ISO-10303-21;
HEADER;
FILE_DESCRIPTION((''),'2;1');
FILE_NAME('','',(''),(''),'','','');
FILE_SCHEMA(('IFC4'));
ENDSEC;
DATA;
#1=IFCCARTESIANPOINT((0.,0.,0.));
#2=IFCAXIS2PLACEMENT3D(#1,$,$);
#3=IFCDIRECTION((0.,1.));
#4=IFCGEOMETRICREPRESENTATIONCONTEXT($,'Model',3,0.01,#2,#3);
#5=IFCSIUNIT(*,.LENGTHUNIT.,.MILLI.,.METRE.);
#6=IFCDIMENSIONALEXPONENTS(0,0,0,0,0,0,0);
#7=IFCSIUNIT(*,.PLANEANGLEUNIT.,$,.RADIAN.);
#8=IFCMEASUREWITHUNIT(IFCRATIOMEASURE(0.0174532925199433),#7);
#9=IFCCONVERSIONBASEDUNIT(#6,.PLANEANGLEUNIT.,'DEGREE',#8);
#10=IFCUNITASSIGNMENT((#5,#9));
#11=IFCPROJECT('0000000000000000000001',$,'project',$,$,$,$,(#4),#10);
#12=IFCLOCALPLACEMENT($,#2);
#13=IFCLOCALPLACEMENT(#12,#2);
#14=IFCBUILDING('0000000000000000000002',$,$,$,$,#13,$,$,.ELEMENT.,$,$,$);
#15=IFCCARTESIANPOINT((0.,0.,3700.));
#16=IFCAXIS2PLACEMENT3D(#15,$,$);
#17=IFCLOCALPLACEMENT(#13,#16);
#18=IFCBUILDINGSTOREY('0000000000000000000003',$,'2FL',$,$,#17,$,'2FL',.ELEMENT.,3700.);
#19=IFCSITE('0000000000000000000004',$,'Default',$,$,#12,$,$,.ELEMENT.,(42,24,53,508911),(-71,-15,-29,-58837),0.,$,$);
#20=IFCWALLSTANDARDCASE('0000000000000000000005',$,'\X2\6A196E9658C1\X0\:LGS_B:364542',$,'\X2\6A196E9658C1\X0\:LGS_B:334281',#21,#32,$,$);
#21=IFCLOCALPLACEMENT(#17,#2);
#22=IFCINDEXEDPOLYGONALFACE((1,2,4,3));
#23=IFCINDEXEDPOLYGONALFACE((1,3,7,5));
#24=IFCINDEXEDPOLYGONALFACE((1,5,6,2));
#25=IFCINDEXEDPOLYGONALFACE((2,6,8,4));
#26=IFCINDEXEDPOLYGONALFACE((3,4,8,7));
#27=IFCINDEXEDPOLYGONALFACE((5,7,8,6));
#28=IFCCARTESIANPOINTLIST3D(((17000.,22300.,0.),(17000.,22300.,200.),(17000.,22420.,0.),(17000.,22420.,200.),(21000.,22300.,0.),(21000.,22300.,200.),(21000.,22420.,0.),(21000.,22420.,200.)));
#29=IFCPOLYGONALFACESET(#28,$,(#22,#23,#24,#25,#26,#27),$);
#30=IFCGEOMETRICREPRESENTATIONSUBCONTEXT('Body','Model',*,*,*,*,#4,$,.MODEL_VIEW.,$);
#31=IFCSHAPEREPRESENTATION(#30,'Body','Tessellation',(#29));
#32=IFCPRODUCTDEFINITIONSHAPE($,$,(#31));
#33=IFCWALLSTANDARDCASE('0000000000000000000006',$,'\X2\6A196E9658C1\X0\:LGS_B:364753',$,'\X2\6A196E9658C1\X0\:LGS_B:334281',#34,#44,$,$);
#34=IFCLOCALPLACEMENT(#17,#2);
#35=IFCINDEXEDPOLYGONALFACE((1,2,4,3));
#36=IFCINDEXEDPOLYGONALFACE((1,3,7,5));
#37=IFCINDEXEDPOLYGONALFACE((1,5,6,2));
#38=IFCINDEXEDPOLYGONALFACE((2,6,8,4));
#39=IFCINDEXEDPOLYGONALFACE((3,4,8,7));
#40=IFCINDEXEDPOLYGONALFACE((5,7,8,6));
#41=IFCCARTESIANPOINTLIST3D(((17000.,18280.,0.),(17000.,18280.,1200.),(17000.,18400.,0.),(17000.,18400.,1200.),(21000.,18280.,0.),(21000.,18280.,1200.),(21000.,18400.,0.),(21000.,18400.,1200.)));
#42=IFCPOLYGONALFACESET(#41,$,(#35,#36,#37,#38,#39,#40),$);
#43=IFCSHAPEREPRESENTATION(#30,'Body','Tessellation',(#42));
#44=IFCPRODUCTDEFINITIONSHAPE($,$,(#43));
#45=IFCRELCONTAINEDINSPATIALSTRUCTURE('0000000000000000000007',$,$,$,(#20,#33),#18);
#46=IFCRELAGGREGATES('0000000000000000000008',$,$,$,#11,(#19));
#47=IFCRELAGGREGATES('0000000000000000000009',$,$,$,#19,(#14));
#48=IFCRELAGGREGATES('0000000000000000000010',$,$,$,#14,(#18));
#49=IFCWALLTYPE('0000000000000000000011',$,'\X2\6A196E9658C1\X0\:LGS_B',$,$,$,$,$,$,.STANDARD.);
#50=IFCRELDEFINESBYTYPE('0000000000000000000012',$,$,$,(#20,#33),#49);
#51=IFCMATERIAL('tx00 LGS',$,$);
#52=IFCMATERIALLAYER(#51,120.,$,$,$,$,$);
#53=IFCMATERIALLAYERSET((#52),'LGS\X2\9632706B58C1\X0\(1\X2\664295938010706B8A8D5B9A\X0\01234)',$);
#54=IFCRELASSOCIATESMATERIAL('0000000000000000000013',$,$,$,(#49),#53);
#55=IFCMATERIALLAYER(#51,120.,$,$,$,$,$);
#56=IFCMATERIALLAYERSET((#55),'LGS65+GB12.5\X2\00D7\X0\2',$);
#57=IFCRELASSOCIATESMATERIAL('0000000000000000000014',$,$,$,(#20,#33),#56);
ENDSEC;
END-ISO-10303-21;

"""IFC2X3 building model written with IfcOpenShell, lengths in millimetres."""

from ifc_helpers import new_model, entity, si_unit, converted_unit, direction, frame, frame_2d, origin, place, context, subcontext, project, spatial, rectangle, extrude, material, layer, layer_set, layer_usage, type_object, element, save


model = new_model("IFC2X3")

# Units and contexts
model_context = context("Model", 3, precision=0.01, world=origin(), true_north=direction((0.0, 1.0)))
body_context = subcontext(model_context, "Body", "Model", "MODEL_VIEW")
ifc_project = project(units=[si_unit("LENGTHUNIT", "METRE", prefix="MILLI"), converted_unit("PLANEANGLEUNIT", "DEGREE", entity("IfcRatioMeasure", 0.0174532925199433), si_unit("PLANEANGLEUNIT", "RADIAN"), dimensions=[0, 0, 0, 0, 0, 0, 0])], contexts=[model_context])

# Site, building, storey
site_placement = place(None, origin())
site = spatial("IfcSite", under=ifc_project, at=site_placement, Name="Default", CompositionType="ELEMENT", RefLatitude=(42, 24, 53, 508911), RefLongitude=(-71, -15, -29, -58837), RefElevation=0.0)
building_placement = place(site_placement, origin())
building = spatial("IfcBuilding", under=site, at=building_placement, CompositionType="ELEMENT")
storey_placement = place(building_placement, frame((0.0, 0.0, 3700.0)))
storey = spatial("IfcBuildingStorey", under=building, at=storey_placement, Name="2FL", LongName="2FL", CompositionType="ELEMENT", Elevation=3700.0)

# Walls
ifc_material_1 = material(Name="tx00 LGS")
ifc_layer_1 = layer(ifc_material_1, 120.0)
ifc_layer_set_1 = layer_set([ifc_layer_1], Name="LGS65+GB12.5×2")
ifc_layer_2 = layer(ifc_material_1, 120.0)
ifc_layer_set_2 = layer_set([ifc_layer_2], Name="LGS防火壁(1時間耐火認定01234)")
wall_type_1 = type_object("IfcWallType", Name="標準壁:LGS_B", PredefinedType="STANDARD", material=ifc_layer_set_2)
ifc_layer_usage_1 = layer_usage(ifc_layer_set_1, "AXIS2", "NEGATIVE", 60.0)
wall_1_placement = place(storey_placement, frame((21000.0, 22360.0, 0.0), z_axis=(0.0, 0.0, 1.0), x_axis=(-1.0, 0.0, 0.0)))
element("IfcWallStandardCase", 1, at=wall_1_placement, inside=storey, type_object=wall_type_1, material=ifc_layer_usage_1, Name="標準壁:LGS_B:364542", ObjectType="標準壁:LGS_B:334281", context=body_context, shape_type="SweptSolid", body=[
    extrude(rectangle(XDim=4000.0, YDim=120.0, at=frame_2d((2000.0, 0.0), x_axis=(-1.0, 0.0))), origin(), (0.0, 0.0, 1.0), 200.0),
])
ifc_layer_usage_2 = layer_usage(ifc_layer_set_1, "AXIS2", "NEGATIVE", 60.0)
wall_2_placement = place(storey_placement, frame((17000.0, 18340.0, 0.0)))
element("IfcWallStandardCase", 2, at=wall_2_placement, inside=storey, type_object=wall_type_1, material=ifc_layer_usage_2, Name="標準壁:LGS_B:364753", ObjectType="標準壁:LGS_B:334281", context=body_context, shape_type="SweptSolid", body=[
    extrude(rectangle(XDim=4000.0, YDim=120.0, at=frame_2d((2000.0, 0.0), x_axis=(-1.0, 0.0))), origin(), (0.0, 0.0, 1.0), 1200.0),
])

save(model, "model.ifc")
